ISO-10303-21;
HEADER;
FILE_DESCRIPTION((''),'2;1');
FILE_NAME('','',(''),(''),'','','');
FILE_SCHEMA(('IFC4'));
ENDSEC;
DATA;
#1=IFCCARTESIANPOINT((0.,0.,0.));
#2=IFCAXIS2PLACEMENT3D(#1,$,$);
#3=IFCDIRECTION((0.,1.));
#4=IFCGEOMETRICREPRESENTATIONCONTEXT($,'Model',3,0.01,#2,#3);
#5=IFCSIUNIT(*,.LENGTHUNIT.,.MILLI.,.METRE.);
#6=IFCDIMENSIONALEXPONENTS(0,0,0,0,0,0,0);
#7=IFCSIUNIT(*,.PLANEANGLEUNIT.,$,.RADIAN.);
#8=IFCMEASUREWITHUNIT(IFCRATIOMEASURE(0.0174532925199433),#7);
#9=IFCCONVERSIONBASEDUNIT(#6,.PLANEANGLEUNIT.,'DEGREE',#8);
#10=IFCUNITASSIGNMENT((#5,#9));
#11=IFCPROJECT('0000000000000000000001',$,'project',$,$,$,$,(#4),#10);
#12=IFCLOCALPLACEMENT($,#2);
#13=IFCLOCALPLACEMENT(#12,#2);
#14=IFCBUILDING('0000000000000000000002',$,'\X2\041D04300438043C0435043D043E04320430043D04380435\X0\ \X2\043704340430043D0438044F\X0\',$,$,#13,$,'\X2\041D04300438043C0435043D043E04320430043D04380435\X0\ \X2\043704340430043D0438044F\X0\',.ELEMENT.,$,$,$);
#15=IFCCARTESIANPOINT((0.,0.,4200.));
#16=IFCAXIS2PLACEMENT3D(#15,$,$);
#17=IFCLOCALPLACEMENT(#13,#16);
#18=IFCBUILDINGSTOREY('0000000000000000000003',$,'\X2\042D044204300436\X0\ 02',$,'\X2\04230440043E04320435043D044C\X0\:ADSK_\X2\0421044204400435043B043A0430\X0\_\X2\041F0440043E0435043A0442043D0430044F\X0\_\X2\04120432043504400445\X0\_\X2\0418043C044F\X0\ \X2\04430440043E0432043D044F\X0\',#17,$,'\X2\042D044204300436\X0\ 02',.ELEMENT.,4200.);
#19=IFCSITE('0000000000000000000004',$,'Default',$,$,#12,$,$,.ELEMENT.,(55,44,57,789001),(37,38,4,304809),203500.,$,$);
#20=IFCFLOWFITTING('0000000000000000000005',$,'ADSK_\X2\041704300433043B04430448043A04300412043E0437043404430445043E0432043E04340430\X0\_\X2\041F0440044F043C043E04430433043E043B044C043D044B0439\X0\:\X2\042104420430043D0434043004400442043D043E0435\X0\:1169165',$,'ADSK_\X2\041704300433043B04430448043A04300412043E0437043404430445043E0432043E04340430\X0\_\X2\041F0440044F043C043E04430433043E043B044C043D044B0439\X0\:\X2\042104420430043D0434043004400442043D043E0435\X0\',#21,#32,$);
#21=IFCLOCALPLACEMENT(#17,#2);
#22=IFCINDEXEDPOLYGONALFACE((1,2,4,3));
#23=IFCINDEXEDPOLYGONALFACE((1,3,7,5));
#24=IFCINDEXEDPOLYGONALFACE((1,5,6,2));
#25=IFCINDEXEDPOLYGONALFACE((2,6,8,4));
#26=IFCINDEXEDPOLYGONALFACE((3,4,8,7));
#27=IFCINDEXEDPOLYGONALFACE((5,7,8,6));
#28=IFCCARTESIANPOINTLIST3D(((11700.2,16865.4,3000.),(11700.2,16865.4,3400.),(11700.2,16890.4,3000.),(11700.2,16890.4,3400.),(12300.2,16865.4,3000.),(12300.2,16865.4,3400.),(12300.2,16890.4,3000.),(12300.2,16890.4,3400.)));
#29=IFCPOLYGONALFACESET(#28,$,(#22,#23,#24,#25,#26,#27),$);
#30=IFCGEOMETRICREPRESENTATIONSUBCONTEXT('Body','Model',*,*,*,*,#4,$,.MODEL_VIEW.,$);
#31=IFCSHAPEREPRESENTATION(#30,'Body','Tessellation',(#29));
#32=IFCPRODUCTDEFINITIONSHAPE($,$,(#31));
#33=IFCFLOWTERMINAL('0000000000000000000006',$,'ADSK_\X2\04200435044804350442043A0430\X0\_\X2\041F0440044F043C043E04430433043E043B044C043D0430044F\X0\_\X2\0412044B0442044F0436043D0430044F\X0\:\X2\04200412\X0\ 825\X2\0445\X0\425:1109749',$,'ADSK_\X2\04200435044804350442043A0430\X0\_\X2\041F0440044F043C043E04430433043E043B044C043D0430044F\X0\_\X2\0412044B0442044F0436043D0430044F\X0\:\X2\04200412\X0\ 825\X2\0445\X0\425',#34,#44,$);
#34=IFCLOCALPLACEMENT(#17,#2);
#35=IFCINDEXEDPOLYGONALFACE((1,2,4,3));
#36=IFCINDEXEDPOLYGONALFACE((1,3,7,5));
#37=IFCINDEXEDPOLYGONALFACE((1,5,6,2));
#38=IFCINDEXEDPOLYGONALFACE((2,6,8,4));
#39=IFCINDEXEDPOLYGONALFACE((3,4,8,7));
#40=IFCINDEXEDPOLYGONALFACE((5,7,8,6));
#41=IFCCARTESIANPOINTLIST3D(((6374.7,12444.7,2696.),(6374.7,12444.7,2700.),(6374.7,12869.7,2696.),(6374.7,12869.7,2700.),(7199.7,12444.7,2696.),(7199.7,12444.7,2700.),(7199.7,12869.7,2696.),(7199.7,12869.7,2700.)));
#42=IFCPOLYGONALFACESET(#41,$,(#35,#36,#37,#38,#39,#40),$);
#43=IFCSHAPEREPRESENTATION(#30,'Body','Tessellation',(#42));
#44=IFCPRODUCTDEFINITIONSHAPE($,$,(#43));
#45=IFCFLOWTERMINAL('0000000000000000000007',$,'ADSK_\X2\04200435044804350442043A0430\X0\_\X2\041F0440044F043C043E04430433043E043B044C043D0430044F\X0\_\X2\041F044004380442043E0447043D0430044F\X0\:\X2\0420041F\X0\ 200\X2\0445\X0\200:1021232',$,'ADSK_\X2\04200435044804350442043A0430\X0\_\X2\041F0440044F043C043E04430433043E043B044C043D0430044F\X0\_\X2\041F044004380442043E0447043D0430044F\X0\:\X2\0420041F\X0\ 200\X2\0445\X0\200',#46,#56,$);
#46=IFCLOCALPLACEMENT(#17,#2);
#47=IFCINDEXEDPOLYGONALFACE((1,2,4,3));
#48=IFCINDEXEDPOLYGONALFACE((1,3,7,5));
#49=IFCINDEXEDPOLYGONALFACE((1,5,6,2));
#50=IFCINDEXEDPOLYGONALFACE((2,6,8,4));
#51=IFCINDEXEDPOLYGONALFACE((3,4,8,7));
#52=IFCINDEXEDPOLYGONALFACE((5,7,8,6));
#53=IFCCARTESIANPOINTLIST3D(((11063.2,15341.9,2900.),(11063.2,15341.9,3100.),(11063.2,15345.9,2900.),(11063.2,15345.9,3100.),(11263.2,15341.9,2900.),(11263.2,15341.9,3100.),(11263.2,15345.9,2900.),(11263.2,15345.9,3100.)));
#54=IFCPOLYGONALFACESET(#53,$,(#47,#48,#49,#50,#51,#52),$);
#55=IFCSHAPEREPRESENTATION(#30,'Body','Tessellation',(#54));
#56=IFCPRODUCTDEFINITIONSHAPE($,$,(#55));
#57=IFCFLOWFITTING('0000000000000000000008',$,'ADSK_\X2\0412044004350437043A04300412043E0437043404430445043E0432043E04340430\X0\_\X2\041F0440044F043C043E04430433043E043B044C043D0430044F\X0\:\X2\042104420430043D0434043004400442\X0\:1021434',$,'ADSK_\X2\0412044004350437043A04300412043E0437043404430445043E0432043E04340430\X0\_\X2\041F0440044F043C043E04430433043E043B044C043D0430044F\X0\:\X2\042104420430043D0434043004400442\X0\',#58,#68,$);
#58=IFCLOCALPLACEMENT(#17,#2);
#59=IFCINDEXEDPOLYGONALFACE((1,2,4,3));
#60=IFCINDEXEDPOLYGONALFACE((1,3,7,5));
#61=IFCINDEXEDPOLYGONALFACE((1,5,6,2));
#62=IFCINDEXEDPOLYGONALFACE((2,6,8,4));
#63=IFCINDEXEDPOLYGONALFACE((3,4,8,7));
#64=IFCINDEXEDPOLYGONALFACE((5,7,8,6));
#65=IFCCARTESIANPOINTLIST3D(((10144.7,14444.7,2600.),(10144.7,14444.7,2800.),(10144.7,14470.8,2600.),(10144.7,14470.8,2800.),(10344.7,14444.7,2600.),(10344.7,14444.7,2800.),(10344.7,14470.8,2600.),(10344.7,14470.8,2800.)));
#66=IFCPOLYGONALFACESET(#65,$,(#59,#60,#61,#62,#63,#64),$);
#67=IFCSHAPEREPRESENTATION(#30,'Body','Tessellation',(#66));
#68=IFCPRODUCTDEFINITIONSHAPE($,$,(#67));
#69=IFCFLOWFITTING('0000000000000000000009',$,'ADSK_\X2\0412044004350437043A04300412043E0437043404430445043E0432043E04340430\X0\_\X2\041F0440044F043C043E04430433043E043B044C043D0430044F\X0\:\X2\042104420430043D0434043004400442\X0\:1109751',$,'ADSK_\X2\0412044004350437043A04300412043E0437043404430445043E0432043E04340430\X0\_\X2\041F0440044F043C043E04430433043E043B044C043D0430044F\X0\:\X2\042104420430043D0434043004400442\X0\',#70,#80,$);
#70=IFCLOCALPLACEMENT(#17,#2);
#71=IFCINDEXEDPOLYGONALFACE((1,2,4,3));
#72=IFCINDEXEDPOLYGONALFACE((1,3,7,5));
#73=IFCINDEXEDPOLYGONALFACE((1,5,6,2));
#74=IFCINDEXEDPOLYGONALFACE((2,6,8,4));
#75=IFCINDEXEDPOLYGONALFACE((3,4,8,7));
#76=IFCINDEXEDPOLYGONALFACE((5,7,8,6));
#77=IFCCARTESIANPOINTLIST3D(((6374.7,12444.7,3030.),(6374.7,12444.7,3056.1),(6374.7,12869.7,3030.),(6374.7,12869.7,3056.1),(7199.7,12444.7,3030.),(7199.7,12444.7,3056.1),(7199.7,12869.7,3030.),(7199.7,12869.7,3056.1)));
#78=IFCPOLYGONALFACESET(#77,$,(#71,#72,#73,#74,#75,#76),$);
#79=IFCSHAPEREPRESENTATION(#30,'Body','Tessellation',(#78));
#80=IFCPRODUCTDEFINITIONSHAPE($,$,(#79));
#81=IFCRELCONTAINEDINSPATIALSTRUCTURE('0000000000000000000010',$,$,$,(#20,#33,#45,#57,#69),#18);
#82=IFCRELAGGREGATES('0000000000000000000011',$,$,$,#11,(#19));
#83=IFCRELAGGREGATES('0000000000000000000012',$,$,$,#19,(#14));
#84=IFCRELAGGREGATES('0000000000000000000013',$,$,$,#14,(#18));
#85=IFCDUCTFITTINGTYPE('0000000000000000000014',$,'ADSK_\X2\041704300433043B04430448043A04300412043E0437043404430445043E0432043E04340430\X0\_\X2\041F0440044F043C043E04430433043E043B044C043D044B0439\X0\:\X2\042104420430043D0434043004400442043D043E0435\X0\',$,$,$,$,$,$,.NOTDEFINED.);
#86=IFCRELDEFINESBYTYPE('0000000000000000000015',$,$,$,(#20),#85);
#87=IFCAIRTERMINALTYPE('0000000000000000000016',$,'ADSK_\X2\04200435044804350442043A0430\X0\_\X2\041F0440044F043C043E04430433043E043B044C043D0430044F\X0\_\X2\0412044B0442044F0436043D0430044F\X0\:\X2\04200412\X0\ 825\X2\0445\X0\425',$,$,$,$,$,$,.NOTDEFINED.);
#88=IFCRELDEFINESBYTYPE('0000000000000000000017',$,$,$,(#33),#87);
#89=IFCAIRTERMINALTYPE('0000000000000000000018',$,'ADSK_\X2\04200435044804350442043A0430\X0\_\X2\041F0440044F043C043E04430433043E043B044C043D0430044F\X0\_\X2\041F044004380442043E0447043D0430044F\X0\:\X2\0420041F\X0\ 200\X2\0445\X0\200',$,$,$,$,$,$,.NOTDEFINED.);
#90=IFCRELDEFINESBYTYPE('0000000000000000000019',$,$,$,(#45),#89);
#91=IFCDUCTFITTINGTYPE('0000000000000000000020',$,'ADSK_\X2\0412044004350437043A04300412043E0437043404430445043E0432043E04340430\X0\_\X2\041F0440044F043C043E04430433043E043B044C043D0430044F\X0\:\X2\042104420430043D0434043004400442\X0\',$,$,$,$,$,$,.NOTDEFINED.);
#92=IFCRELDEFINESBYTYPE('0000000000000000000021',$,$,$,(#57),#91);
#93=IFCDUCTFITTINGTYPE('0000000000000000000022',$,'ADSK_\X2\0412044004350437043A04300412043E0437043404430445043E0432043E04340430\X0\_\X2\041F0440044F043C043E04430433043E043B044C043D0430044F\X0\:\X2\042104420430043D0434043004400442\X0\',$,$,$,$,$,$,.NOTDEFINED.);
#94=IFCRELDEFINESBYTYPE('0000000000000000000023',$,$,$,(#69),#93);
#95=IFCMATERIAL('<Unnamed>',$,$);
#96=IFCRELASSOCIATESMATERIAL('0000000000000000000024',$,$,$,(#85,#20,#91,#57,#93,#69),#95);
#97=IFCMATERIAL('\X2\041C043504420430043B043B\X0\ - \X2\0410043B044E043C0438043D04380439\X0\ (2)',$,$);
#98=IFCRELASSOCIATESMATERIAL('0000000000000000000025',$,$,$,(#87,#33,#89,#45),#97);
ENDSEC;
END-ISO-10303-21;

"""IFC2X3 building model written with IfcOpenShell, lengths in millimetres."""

from ifc_helpers import new_model, entity, si_unit, converted_unit, direction, frame, origin, origin_2d_with_axis, place, context, subcontext, project, spatial, rectangle, extrude, source, transform, mapped, material, type_object, type_shapes, element, save


model = new_model("IFC2X3")

# Units and contexts
model_context = context("Model", 3, precision=0.01, world=origin(), true_north=direction((0.0, 1.0)))
body_context = subcontext(model_context, "Body", "Model", "MODEL_VIEW")
ifc_project = project(units=[si_unit("LENGTHUNIT", "METRE", prefix="MILLI"), converted_unit("PLANEANGLEUNIT", "DEGREE", entity("IfcRatioMeasure", 0.0174532925199433), si_unit("PLANEANGLEUNIT", "RADIAN"), dimensions=[0, 0, 0, 0, 0, 0, 0])], contexts=[model_context])

# Site, building, storey
site_placement = place(None, origin())
site = spatial("IfcSite", under=ifc_project, at=site_placement, Name="Default", CompositionType="ELEMENT", RefLatitude=(55, 44, 57, 789001), RefLongitude=(37, 38, 4, 304809), RefElevation=203500.0)
building_placement = place(site_placement, origin())
building = spatial("IfcBuilding", under=site, at=building_placement, Name="Наименование здания", LongName="Наименование здания", CompositionType="ELEMENT")
storey_placement = place(building_placement, frame((0.0, 0.0, 4200.0)))
storey = spatial("IfcBuildingStorey", under=building, at=storey_placement, Name="Этаж 02", ObjectType="Уровень:ADSK_Стрелка_Проектная_Вверх_Имя уровня", LongName="Этаж 02", CompositionType="ELEMENT", Elevation=4200.0)

# Flow fitting
ifc_material_1 = material(Name="<Unnamed>")
duct_fitting_type_1 = type_object("IfcDuctFittingType", Name="ADSK_ЗаглушкаВоздуховода_Прямоугольный:Стандартное", PredefinedType="NOTDEFINED", material=ifc_material_1)
shared_shape_1 = source(origin(), body_context, "Body", "SweptSolid", [
    extrude(rectangle(XDim=25.0, YDim=600.0, at=origin_2d_with_axis()), frame((12.5, 0.0, -200.0)), (0.0, 0.0, 1.0), 400.0),
])
type_shapes(duct_fitting_type_1, [shared_shape_1])
flow_fitting_1_placement = place(storey_placement, frame((12000.2, 16865.4, 3200.0), z_axis=(0.0, 0.0, 1.0), x_axis=(0.0, 1.0, 0.0)))
element("IfcFlowFitting", 1, at=flow_fitting_1_placement, inside=storey, type_object=duct_fitting_type_1, material=ifc_material_1, Name="ADSK_ЗаглушкаВоздуховода_Прямоугольный:Стандартное:1169165", ObjectType="ADSK_ЗаглушкаВоздуховода_Прямоугольный:Стандартное", context=body_context, shape_type="MappedRepresentation", body=[
    mapped(shared_shape_1, transform((0.0, 0.0, 0.0), scale=1.0)),
])

# Flow terminals
ifc_material_2 = material(Name="Металл - Алюминий (2)")
air_terminal_type_1 = type_object("IfcAirTerminalType", Name="ADSK_Решетка_Прямоугольная_Вытяжная:РВ 825х425", PredefinedType="NOTDEFINED", material=ifc_material_2)
shared_shape_2 = source(origin(), body_context, "Body", "SweptSolid", [
    extrude(rectangle(XDim=4.0, YDim=825.0, at=origin_2d_with_axis()), frame((0.0, -2.0, -212.5), z_axis=(0.0, 0.0, 1.0), x_axis=(0.0, 1.0, 0.0)), (0.0, 0.0, 1.0), 425.0),
])
type_shapes(air_terminal_type_1, [shared_shape_2])
flow_terminal_1_placement = place(storey_placement, frame((6787.2, 12657.2, 2700.0), z_axis=(0.0, 1.0, 0.0), x_axis=(-1.0, 0.0, 0.0)))
element("IfcFlowTerminal", 2, at=flow_terminal_1_placement, inside=storey, type_object=air_terminal_type_1, material=ifc_material_2, Name="ADSK_Решетка_Прямоугольная_Вытяжная:РВ 825х425:1109749", ObjectType="ADSK_Решетка_Прямоугольная_Вытяжная:РВ 825х425", context=body_context, shape_type="MappedRepresentation", body=[
    mapped(shared_shape_2, transform((0.0, 0.0, 0.0), scale=1.0)),
])
air_terminal_type_2 = type_object("IfcAirTerminalType", Name="ADSK_Решетка_Прямоугольная_Приточная:РП 200х200", PredefinedType="NOTDEFINED", material=ifc_material_2)
shared_shape_3 = source(origin(), body_context, "Body", "SweptSolid", [
    extrude(rectangle(XDim=4.0, YDim=200.0, at=origin_2d_with_axis()), frame((0.0, -2.0, -100.0), z_axis=(0.0, 0.0, 1.0), x_axis=(0.0, 1.0, 0.0)), (0.0, 0.0, 1.0), 200.0),
])
type_shapes(air_terminal_type_2, [shared_shape_3])
flow_terminal_2_placement = place(storey_placement, frame((11163.2, 15341.9, 3000.0), z_axis=(0.0, 0.0, 1.0), x_axis=(-1.0, 0.0, 0.0)))
element("IfcFlowTerminal", 3, at=flow_terminal_2_placement, inside=storey, type_object=air_terminal_type_2, material=ifc_material_2, Name="ADSK_Решетка_Прямоугольная_Приточная:РП 200х200:1021232", ObjectType="ADSK_Решетка_Прямоугольная_Приточная:РП 200х200", context=body_context, shape_type="MappedRepresentation", body=[
    mapped(shared_shape_3, transform((0.0, 0.0, 0.0), scale=1.0)),
])

# Flow fittings
duct_fitting_type_2 = type_object("IfcDuctFittingType", Name="ADSK_ВрезкаВоздуховода_Прямоугольная:Стандарт", PredefinedType="NOTDEFINED", material=ifc_material_1)
shared_shape_4 = source(origin(), body_context, "Body", "SweptSolid", [
    extrude(rectangle(XDim=26.1, YDim=200.0, at=origin_2d_with_axis()), frame((7.0, 0.0, -100.0)), (0.0, 0.0, 1.0), 200.0),
])
type_shapes(duct_fitting_type_2, [shared_shape_4])
flow_fitting_2_placement = place(storey_placement, frame((10244.7, 14450.8, 2700.0), z_axis=(1.0, 0.0, 0.0), x_axis=(0.0, 1.0, 0.0)))
element("IfcFlowFitting", 4, at=flow_fitting_2_placement, inside=storey, type_object=duct_fitting_type_2, material=ifc_material_1, Name="ADSK_ВрезкаВоздуховода_Прямоугольная:Стандарт:1021434", ObjectType="ADSK_ВрезкаВоздуховода_Прямоугольная:Стандарт", context=body_context, shape_type="MappedRepresentation", body=[
    mapped(shared_shape_4, transform((0.0, 0.0, 0.0), scale=1.0)),
])
duct_fitting_type_3 = type_object("IfcDuctFittingType", Name="ADSK_ВрезкаВоздуховода_Прямоугольная:Стандарт", PredefinedType="NOTDEFINED", material=ifc_material_1)
shared_shape_5 = source(origin(), body_context, "Body", "SweptSolid", [
    extrude(rectangle(XDim=825.0, YDim=26.1, at=origin_2d_with_axis()), frame((7.0, 0.0, -212.5), z_axis=(0.0, 0.0, 1.0), x_axis=(0.0, -1.0, 0.0)), (0.0, 0.0, 1.0), 425.0),
])
type_shapes(duct_fitting_type_3, [shared_shape_5])
flow_fitting_3_placement = place(storey_placement, frame((6787.2, 12657.2, 3050.0), z_axis=(0.0, -1.0, 0.0), x_axis=(0.0, 0.0, -1.0)))
element("IfcFlowFitting", 5, at=flow_fitting_3_placement, inside=storey, type_object=duct_fitting_type_3, material=ifc_material_1, Name="ADSK_ВрезкаВоздуховода_Прямоугольная:Стандарт:1109751", ObjectType="ADSK_ВрезкаВоздуховода_Прямоугольная:Стандарт", context=body_context, shape_type="MappedRepresentation", body=[
    mapped(shared_shape_5, transform((0.0, 0.0, 0.0), scale=1.0)),
])

save(model, "model.ifc")
